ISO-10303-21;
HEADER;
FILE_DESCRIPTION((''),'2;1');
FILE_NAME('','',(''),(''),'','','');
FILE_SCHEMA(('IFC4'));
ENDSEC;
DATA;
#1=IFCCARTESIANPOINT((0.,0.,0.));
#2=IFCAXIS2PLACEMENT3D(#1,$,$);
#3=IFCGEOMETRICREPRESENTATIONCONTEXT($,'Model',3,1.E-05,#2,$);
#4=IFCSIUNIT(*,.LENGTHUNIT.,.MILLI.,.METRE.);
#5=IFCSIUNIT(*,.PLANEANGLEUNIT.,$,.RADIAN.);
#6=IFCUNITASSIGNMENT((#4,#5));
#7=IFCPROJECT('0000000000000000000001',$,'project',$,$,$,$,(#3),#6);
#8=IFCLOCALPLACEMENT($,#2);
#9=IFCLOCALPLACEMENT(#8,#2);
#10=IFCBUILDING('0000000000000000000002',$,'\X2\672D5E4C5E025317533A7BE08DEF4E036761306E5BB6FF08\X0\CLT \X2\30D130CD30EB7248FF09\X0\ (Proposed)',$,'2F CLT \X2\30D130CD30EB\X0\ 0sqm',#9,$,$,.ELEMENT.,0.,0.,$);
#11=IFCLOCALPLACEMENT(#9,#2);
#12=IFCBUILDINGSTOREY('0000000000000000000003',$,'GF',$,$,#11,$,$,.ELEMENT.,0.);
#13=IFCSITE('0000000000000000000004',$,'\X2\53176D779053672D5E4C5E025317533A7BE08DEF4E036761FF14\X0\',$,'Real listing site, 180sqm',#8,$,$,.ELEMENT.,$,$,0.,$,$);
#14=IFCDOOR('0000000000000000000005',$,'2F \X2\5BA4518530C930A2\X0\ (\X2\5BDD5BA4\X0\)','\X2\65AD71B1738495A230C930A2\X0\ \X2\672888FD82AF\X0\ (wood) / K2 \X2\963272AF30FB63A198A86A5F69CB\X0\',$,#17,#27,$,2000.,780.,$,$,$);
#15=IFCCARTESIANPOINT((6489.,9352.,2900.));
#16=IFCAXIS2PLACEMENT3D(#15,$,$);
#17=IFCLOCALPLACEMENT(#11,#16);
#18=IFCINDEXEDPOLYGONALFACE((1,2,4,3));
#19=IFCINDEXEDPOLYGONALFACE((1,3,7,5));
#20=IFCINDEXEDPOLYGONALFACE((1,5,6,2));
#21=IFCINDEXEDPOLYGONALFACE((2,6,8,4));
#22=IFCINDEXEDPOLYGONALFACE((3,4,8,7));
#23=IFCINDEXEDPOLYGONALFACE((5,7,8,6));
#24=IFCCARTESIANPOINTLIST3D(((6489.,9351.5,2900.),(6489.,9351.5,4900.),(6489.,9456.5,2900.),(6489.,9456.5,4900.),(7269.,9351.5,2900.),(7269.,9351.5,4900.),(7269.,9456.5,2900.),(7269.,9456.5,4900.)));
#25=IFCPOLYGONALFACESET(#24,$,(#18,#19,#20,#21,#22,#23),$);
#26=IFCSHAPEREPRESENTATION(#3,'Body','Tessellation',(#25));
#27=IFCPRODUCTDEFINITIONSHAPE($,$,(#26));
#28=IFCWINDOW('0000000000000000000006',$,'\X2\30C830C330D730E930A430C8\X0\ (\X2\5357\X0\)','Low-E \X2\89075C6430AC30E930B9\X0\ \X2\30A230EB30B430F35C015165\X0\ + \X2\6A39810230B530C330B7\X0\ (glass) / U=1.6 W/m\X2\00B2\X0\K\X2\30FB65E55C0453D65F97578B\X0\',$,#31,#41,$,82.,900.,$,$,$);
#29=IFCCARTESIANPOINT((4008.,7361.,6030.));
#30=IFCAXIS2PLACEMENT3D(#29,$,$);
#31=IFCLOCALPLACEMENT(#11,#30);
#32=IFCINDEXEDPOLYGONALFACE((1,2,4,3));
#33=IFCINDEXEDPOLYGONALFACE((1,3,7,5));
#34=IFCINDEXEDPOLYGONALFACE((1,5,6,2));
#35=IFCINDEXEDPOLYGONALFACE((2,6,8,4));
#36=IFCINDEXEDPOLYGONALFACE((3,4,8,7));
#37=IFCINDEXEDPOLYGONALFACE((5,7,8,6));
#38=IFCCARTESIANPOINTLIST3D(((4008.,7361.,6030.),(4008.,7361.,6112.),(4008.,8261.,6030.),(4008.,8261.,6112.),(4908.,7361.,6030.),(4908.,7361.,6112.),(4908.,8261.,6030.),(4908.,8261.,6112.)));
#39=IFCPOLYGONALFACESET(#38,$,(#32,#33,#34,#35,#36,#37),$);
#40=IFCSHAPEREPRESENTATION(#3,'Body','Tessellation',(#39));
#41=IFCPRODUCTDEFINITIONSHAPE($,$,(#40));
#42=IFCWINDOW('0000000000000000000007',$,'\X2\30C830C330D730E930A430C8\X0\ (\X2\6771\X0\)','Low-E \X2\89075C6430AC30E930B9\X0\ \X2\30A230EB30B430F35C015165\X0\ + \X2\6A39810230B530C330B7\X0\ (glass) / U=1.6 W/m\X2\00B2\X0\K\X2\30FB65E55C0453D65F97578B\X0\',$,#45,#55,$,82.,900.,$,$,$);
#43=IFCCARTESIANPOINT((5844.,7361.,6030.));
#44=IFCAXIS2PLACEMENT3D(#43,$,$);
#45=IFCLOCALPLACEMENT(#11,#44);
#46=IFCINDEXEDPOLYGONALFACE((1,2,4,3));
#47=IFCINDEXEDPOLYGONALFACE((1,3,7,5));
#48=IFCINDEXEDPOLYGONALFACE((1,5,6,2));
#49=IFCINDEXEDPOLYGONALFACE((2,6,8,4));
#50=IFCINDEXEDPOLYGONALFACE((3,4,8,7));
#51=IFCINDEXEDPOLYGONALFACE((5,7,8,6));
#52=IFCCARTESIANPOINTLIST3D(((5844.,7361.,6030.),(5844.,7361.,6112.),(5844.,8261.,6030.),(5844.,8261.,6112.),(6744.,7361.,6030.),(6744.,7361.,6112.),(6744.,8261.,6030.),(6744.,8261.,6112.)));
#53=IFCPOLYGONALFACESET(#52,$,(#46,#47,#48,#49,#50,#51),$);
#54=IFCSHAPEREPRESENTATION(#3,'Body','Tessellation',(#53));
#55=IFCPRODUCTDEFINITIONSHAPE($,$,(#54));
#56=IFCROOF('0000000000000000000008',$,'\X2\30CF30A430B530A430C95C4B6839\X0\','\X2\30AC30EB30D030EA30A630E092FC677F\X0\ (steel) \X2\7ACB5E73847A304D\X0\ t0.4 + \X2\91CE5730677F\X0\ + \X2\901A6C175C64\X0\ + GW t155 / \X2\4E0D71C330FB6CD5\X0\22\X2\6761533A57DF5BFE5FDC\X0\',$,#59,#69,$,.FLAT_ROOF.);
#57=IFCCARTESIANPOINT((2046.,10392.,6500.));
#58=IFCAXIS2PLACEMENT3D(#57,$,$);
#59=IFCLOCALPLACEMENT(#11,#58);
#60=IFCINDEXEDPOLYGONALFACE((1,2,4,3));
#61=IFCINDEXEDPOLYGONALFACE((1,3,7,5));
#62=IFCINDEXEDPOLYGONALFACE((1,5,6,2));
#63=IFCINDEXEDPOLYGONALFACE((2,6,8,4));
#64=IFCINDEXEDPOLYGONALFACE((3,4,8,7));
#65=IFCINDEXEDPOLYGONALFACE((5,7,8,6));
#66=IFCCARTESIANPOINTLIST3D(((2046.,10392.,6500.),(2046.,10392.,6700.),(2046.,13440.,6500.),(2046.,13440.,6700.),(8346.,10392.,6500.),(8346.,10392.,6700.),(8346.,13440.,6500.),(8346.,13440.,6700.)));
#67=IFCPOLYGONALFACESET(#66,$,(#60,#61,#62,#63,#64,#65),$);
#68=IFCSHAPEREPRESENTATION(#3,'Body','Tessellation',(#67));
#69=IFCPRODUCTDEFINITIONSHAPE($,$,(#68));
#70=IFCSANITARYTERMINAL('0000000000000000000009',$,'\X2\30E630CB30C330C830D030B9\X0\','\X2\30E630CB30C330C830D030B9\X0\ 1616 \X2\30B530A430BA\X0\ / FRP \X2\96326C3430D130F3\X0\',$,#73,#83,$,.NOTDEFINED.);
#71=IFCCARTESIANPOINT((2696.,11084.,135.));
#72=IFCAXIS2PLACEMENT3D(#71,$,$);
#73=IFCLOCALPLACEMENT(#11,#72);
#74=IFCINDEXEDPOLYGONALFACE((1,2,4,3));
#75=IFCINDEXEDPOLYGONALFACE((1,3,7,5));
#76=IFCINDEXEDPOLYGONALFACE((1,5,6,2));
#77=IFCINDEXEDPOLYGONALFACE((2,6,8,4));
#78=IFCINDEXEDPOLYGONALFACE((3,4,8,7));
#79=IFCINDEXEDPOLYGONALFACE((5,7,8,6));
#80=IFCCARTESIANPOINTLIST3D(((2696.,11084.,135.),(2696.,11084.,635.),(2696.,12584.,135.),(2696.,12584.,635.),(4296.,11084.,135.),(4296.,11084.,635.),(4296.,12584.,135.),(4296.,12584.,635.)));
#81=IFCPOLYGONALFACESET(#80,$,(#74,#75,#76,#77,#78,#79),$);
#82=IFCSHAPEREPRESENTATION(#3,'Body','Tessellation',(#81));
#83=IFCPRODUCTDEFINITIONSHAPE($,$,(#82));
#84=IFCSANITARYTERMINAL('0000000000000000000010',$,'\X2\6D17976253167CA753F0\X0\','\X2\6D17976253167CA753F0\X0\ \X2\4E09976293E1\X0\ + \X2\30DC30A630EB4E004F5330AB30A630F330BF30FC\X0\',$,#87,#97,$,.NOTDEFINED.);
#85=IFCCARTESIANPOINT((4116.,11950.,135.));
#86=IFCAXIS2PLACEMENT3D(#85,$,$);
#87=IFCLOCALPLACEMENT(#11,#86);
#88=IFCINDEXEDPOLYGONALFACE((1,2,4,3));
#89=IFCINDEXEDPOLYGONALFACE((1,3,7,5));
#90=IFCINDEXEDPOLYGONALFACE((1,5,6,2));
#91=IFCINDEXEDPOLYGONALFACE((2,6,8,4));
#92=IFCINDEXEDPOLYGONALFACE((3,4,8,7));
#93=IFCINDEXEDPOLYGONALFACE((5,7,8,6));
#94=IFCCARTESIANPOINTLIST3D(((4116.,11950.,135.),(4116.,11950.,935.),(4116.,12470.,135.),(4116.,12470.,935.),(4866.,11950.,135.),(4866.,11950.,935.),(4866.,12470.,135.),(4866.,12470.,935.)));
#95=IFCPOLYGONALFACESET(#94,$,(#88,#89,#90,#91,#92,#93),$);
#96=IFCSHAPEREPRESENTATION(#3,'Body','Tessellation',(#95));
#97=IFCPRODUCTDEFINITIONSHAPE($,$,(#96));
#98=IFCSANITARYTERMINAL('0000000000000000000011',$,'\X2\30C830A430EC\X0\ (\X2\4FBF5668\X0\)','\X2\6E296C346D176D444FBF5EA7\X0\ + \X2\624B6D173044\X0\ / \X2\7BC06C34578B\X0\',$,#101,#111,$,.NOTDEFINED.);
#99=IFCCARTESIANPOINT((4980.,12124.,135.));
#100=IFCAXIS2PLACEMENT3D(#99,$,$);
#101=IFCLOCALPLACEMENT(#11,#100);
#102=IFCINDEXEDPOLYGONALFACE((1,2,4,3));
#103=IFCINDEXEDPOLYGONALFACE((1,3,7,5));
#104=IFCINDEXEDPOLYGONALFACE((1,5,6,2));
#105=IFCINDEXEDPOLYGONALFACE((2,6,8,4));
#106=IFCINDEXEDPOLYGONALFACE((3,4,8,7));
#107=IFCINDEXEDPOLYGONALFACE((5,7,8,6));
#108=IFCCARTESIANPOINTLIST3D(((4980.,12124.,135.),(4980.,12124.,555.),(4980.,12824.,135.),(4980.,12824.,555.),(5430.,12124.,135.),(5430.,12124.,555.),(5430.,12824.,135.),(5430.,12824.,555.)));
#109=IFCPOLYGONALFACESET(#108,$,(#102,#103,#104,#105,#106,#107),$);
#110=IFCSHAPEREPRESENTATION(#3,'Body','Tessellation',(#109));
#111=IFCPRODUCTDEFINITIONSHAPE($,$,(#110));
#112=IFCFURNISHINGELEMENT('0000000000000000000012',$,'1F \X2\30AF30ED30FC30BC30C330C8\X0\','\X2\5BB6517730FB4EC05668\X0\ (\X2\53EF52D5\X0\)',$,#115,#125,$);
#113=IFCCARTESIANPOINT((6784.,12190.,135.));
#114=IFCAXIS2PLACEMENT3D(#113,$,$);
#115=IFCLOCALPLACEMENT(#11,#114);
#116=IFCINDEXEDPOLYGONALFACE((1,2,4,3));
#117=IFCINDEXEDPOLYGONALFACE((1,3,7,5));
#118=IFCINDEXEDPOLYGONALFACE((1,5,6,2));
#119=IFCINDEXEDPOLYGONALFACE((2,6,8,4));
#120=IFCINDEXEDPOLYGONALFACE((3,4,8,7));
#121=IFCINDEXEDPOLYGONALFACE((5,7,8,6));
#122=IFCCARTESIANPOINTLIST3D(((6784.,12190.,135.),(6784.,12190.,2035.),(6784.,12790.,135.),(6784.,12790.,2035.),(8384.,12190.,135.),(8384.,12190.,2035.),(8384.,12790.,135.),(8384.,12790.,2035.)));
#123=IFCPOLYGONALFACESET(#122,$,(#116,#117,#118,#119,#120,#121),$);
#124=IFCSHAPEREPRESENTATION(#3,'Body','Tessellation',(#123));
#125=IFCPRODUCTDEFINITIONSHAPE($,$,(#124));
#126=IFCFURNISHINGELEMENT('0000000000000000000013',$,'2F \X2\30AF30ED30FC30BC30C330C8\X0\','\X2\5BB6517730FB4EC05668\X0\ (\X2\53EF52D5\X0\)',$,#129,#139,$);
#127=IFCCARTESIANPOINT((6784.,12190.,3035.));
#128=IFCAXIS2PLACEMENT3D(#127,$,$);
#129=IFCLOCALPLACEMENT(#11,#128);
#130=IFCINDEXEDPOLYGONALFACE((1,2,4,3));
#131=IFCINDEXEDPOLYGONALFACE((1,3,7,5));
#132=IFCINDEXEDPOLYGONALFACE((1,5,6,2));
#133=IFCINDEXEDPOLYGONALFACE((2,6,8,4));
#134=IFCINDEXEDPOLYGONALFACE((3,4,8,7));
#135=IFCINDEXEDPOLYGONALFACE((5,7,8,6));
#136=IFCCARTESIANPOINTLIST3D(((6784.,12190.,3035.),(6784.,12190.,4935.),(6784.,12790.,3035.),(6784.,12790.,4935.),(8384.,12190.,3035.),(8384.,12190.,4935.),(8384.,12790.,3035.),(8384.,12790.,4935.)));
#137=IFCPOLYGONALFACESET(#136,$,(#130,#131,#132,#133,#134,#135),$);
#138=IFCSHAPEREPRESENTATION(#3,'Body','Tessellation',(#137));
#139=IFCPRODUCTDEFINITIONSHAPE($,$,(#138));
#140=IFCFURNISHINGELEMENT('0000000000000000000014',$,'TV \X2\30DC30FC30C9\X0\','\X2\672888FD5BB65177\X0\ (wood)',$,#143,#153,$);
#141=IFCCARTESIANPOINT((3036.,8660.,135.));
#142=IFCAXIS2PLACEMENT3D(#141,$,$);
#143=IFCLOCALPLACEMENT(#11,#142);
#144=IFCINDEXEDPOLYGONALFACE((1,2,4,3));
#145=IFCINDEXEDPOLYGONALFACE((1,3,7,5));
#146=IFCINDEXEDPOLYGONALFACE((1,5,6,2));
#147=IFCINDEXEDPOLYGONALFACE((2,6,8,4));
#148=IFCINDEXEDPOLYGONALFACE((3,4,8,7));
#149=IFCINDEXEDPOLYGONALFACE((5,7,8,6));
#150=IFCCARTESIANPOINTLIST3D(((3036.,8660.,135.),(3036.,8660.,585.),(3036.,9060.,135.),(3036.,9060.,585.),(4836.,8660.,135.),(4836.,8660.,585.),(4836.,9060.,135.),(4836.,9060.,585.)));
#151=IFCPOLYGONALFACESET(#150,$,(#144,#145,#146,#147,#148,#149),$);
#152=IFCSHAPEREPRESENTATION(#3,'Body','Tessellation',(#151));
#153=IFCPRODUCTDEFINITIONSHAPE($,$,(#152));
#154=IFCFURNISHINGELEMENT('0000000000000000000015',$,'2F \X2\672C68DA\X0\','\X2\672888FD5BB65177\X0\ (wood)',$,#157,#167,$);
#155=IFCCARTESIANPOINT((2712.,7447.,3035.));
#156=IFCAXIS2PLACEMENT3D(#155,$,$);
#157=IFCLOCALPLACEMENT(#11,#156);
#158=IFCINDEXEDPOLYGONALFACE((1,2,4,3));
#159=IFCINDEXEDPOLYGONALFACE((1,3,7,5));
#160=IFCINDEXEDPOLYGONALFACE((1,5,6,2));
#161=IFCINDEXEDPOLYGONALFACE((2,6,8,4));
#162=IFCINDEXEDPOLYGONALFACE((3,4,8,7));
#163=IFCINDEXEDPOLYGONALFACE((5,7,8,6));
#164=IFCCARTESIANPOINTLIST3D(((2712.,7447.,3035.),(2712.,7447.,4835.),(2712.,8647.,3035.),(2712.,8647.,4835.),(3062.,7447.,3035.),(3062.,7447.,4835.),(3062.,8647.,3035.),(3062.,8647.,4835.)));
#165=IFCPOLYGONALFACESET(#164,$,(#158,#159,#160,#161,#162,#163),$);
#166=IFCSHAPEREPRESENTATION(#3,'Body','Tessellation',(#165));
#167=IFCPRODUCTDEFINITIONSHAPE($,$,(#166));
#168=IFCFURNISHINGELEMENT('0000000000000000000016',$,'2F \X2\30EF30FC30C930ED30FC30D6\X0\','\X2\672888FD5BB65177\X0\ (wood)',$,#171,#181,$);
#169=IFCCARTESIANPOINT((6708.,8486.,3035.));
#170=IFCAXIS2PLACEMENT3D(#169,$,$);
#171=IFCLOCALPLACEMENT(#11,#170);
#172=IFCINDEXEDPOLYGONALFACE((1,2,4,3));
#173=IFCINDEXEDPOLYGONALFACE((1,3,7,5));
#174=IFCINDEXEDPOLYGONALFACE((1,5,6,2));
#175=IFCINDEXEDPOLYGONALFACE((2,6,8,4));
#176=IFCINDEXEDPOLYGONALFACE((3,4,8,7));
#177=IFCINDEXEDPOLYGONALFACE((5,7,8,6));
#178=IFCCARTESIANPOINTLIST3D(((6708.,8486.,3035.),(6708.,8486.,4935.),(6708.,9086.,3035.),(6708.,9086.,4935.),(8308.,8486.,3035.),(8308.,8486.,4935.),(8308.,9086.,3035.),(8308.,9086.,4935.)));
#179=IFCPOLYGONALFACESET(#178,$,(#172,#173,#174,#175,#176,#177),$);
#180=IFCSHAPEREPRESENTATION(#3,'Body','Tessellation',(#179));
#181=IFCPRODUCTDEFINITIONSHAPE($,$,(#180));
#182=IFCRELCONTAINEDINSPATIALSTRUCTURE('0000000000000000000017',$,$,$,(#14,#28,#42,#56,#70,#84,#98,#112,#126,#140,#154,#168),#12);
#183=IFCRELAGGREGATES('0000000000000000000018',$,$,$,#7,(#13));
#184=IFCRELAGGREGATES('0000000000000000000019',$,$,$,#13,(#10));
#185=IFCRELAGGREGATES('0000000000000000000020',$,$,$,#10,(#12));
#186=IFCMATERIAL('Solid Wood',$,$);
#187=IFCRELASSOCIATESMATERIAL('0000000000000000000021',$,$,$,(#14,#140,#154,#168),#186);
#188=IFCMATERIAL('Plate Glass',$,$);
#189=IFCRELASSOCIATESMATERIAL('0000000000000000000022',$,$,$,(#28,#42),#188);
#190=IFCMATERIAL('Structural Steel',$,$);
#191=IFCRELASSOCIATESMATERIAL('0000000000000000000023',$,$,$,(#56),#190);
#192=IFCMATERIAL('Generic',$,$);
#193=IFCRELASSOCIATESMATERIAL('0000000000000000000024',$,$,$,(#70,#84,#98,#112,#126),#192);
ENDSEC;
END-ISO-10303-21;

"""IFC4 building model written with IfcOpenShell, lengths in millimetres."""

from ifc_helpers import new_model, si_unit, frame, frame_2d, origin, place, context, project, spatial, rectangle, extrude, material, element, save


model = new_model("IFC4")

# Units and contexts
model_context = context("Model", 3, precision=1e-05, world=origin())
ifc_project = project(units=[si_unit("LENGTHUNIT", "METRE", prefix="MILLI"), si_unit("PLANEANGLEUNIT", "RADIAN")], contexts=[model_context])

# Site, building, storey
site_placement = place(None, origin())
site = spatial("IfcSite", under=ifc_project, at=site_placement, Name="北海道札幌市北区篠路七条４", ObjectType="Real listing site, 180sqm", CompositionType="ELEMENT", RefElevation=0.0)
building_placement = place(site_placement, origin())
building = spatial("IfcBuilding", under=site, at=building_placement, Name="札幌市北区篠路七条の家（CLT パネル版） (Proposed)", ObjectType="2F CLT パネル 0sqm", CompositionType="ELEMENT", ElevationOfRefHeight=0.0, ElevationOfTerrain=0.0)
storey_placement = place(building_placement, origin())
storey = spatial("IfcBuildingStorey", under=building, at=storey_placement, Name="GF", CompositionType="ELEMENT", Elevation=0.0)

# Shared definitions
ifc_material_1 = material(Name="Solid Wood")
ifc_material_2 = material(Name="Plate Glass")

# Door
door_1_placement = place(storey_placement, frame((6489.0, 9352.0, 2900.0)))
element("IfcDoor", 1, at=door_1_placement, inside=storey, material=ifc_material_1, Name="2F 室内ドア (寝室)", Description="断熱玄関ドア 木製芯 (wood) / K2 防犯・採風機構", OverallHeight=2000.0, OverallWidth=780.0, context=model_context, shape_type="SweptSolid", body=[
    extrude(rectangle(XDim=780.0, YDim=105.0, at=frame_2d((390.0, 52.0))), frame((6489.0, 9352.0, 2900.0)), (0.0, 0.0, 1.0), 2000.0),
])

# Windows
window_1_placement = place(storey_placement, frame((4008.0, 7361.0, 6030.0)))
element("IfcWindow", 2, at=window_1_placement, inside=storey, material=ifc_material_2, Name="トップライト (南)", Description="Low-E 複層ガラス アルゴン封入 + 樹脂サッシ (glass) / U=1.6 W/m²K・日射取得型", OverallHeight=82.0, OverallWidth=900.0, context=model_context, shape_type="SweptSolid", body=[
    extrude(rectangle(XDim=900.0, YDim=900.0, at=frame_2d((450.0, 450.0))), frame((4008.0, 7361.0, 6030.0)), (0.0, 0.0, 1.0), 82.0),
])
window_2_placement = place(storey_placement, frame((5844.0, 7361.0, 6030.0)))
element("IfcWindow", 3, at=window_2_placement, inside=storey, material=ifc_material_2, Name="トップライト (東)", Description="Low-E 複層ガラス アルゴン封入 + 樹脂サッシ (glass) / U=1.6 W/m²K・日射取得型", OverallHeight=82.0, OverallWidth=900.0, context=model_context, shape_type="SweptSolid", body=[
    extrude(rectangle(XDim=900.0, YDim=900.0, at=frame_2d((450.0, 450.0))), frame((5844.0, 7361.0, 6030.0)), (0.0, 0.0, 1.0), 82.0),
])

# Roof
ifc_material_3 = material(Name="Structural Steel")
roof_placement = place(storey_placement, frame((2046.0, 10392.0, 6500.0)))
element("IfcRoof", 4, at=roof_placement, inside=storey, material=ifc_material_3, Name="ハイサイド屋根", Description="ガルバリウム鋼板 (steel) 立平葺き t0.4 + 野地板 + 通気層 + GW t155 / 不燃・法22条区域対応", PredefinedType="FLAT_ROOF", context=model_context, shape_type="SweptSolid", body=[
    extrude(rectangle(XDim=6300.0, YDim=3048.0, at=frame_2d((3150.0, 1524.0))), frame((2046.0, 10392.0, 6500.0)), (0.0, 0.0, 1.0), 200.0),
])

# Sanitary terminals
ifc_material_4 = material(Name="Generic")
sanitary_terminal_1_placement = place(storey_placement, frame((2696.0, 11084.0, 135.0)))
element("IfcSanitaryTerminal", 5, at=sanitary_terminal_1_placement, inside=storey, material=ifc_material_4, Name="ユニットバス", Description="ユニットバス 1616 サイズ / FRP 防水パン", PredefinedType="NOTDEFINED", context=model_context, shape_type="SweptSolid", body=[
    extrude(rectangle(XDim=1600.0, YDim=1500.0, at=frame_2d((800.0, 750.0))), frame((2696.0, 11084.0, 135.0)), (0.0, 0.0, 1.0), 500.0),
])
sanitary_terminal_2_placement = place(storey_placement, frame((4116.0, 11950.0, 135.0)))
element("IfcSanitaryTerminal", 6, at=sanitary_terminal_2_placement, inside=storey, material=ifc_material_4, Name="洗面化粧台", Description="洗面化粧台 三面鏡 + ボウル一体カウンター", PredefinedType="NOTDEFINED", context=model_context, shape_type="SweptSolid", body=[
    extrude(rectangle(XDim=750.0, YDim=520.0, at=frame_2d((375.0, 260.0))), frame((4116.0, 11950.0, 135.0)), (0.0, 0.0, 1.0), 800.0),
])
sanitary_terminal_3_placement = place(storey_placement, frame((4980.0, 12124.0, 135.0)))
element("IfcSanitaryTerminal", 7, at=sanitary_terminal_3_placement, inside=storey, material=ifc_material_4, Name="トイレ (便器)", Description="温水洗浄便座 + 手洗い / 節水型", PredefinedType="NOTDEFINED", context=model_context, shape_type="SweptSolid", body=[
    extrude(rectangle(XDim=450.0, YDim=700.0, at=frame_2d((225.0, 350.0))), frame((4980.0, 12124.0, 135.0)), (0.0, 0.0, 1.0), 420.0),
])

# Furnishing elements
furnishing_1_placement = place(storey_placement, frame((6784.0, 12190.0, 135.0)))
element("IfcFurnishingElement", 8, at=furnishing_1_placement, inside=storey, material=ifc_material_4, Name="1F クローゼット", Description="家具・什器 (可動)", context=model_context, shape_type="SweptSolid", body=[
    extrude(rectangle(XDim=1600.0, YDim=600.0, at=frame_2d((800.0, 300.0))), frame((6784.0, 12190.0, 135.0)), (0.0, 0.0, 1.0), 1900.0),
])
furnishing_2_placement = place(storey_placement, frame((6784.0, 12190.0, 3035.0)))
element("IfcFurnishingElement", 9, at=furnishing_2_placement, inside=storey, material=ifc_material_4, Name="2F クローゼット", Description="家具・什器 (可動)", context=model_context, shape_type="SweptSolid", body=[
    extrude(rectangle(XDim=1600.0, YDim=600.0, at=frame_2d((800.0, 300.0))), frame((6784.0, 12190.0, 3035.0)), (0.0, 0.0, 1.0), 1900.0),
])
furnishing_3_placement = place(storey_placement, frame((3036.0, 8660.0, 135.0)))
element("IfcFurnishingElement", 10, at=furnishing_3_placement, inside=storey, material=ifc_material_1, Name="TV ボード", Description="木製家具 (wood)", context=model_context, shape_type="SweptSolid", body=[
    extrude(rectangle(XDim=1800.0, YDim=400.0, at=frame_2d((900.0, 200.0))), frame((3036.0, 8660.0, 135.0)), (0.0, 0.0, 1.0), 450.0),
])
furnishing_4_placement = place(storey_placement, frame((2712.0, 7447.0, 3035.0)))
element("IfcFurnishingElement", 11, at=furnishing_4_placement, inside=storey, material=ifc_material_1, Name="2F 本棚", Description="木製家具 (wood)", context=model_context, shape_type="SweptSolid", body=[
    extrude(rectangle(XDim=350.0, YDim=1200.0, at=frame_2d((175.0, 600.0))), frame((2712.0, 7447.0, 3035.0)), (0.0, 0.0, 1.0), 1800.0),
])
furnishing_5_placement = place(storey_placement, frame((6708.0, 8486.0, 3035.0)))
element("IfcFurnishingElement", 12, at=furnishing_5_placement, inside=storey, material=ifc_material_1, Name="2F ワードローブ", Description="木製家具 (wood)", context=model_context, shape_type="SweptSolid", body=[
    extrude(rectangle(XDim=1600.0, YDim=600.0, at=frame_2d((800.0, 300.0))), frame((6708.0, 8486.0, 3035.0)), (0.0, 0.0, 1.0), 1900.0),
])

save(model, "model.ifc")
